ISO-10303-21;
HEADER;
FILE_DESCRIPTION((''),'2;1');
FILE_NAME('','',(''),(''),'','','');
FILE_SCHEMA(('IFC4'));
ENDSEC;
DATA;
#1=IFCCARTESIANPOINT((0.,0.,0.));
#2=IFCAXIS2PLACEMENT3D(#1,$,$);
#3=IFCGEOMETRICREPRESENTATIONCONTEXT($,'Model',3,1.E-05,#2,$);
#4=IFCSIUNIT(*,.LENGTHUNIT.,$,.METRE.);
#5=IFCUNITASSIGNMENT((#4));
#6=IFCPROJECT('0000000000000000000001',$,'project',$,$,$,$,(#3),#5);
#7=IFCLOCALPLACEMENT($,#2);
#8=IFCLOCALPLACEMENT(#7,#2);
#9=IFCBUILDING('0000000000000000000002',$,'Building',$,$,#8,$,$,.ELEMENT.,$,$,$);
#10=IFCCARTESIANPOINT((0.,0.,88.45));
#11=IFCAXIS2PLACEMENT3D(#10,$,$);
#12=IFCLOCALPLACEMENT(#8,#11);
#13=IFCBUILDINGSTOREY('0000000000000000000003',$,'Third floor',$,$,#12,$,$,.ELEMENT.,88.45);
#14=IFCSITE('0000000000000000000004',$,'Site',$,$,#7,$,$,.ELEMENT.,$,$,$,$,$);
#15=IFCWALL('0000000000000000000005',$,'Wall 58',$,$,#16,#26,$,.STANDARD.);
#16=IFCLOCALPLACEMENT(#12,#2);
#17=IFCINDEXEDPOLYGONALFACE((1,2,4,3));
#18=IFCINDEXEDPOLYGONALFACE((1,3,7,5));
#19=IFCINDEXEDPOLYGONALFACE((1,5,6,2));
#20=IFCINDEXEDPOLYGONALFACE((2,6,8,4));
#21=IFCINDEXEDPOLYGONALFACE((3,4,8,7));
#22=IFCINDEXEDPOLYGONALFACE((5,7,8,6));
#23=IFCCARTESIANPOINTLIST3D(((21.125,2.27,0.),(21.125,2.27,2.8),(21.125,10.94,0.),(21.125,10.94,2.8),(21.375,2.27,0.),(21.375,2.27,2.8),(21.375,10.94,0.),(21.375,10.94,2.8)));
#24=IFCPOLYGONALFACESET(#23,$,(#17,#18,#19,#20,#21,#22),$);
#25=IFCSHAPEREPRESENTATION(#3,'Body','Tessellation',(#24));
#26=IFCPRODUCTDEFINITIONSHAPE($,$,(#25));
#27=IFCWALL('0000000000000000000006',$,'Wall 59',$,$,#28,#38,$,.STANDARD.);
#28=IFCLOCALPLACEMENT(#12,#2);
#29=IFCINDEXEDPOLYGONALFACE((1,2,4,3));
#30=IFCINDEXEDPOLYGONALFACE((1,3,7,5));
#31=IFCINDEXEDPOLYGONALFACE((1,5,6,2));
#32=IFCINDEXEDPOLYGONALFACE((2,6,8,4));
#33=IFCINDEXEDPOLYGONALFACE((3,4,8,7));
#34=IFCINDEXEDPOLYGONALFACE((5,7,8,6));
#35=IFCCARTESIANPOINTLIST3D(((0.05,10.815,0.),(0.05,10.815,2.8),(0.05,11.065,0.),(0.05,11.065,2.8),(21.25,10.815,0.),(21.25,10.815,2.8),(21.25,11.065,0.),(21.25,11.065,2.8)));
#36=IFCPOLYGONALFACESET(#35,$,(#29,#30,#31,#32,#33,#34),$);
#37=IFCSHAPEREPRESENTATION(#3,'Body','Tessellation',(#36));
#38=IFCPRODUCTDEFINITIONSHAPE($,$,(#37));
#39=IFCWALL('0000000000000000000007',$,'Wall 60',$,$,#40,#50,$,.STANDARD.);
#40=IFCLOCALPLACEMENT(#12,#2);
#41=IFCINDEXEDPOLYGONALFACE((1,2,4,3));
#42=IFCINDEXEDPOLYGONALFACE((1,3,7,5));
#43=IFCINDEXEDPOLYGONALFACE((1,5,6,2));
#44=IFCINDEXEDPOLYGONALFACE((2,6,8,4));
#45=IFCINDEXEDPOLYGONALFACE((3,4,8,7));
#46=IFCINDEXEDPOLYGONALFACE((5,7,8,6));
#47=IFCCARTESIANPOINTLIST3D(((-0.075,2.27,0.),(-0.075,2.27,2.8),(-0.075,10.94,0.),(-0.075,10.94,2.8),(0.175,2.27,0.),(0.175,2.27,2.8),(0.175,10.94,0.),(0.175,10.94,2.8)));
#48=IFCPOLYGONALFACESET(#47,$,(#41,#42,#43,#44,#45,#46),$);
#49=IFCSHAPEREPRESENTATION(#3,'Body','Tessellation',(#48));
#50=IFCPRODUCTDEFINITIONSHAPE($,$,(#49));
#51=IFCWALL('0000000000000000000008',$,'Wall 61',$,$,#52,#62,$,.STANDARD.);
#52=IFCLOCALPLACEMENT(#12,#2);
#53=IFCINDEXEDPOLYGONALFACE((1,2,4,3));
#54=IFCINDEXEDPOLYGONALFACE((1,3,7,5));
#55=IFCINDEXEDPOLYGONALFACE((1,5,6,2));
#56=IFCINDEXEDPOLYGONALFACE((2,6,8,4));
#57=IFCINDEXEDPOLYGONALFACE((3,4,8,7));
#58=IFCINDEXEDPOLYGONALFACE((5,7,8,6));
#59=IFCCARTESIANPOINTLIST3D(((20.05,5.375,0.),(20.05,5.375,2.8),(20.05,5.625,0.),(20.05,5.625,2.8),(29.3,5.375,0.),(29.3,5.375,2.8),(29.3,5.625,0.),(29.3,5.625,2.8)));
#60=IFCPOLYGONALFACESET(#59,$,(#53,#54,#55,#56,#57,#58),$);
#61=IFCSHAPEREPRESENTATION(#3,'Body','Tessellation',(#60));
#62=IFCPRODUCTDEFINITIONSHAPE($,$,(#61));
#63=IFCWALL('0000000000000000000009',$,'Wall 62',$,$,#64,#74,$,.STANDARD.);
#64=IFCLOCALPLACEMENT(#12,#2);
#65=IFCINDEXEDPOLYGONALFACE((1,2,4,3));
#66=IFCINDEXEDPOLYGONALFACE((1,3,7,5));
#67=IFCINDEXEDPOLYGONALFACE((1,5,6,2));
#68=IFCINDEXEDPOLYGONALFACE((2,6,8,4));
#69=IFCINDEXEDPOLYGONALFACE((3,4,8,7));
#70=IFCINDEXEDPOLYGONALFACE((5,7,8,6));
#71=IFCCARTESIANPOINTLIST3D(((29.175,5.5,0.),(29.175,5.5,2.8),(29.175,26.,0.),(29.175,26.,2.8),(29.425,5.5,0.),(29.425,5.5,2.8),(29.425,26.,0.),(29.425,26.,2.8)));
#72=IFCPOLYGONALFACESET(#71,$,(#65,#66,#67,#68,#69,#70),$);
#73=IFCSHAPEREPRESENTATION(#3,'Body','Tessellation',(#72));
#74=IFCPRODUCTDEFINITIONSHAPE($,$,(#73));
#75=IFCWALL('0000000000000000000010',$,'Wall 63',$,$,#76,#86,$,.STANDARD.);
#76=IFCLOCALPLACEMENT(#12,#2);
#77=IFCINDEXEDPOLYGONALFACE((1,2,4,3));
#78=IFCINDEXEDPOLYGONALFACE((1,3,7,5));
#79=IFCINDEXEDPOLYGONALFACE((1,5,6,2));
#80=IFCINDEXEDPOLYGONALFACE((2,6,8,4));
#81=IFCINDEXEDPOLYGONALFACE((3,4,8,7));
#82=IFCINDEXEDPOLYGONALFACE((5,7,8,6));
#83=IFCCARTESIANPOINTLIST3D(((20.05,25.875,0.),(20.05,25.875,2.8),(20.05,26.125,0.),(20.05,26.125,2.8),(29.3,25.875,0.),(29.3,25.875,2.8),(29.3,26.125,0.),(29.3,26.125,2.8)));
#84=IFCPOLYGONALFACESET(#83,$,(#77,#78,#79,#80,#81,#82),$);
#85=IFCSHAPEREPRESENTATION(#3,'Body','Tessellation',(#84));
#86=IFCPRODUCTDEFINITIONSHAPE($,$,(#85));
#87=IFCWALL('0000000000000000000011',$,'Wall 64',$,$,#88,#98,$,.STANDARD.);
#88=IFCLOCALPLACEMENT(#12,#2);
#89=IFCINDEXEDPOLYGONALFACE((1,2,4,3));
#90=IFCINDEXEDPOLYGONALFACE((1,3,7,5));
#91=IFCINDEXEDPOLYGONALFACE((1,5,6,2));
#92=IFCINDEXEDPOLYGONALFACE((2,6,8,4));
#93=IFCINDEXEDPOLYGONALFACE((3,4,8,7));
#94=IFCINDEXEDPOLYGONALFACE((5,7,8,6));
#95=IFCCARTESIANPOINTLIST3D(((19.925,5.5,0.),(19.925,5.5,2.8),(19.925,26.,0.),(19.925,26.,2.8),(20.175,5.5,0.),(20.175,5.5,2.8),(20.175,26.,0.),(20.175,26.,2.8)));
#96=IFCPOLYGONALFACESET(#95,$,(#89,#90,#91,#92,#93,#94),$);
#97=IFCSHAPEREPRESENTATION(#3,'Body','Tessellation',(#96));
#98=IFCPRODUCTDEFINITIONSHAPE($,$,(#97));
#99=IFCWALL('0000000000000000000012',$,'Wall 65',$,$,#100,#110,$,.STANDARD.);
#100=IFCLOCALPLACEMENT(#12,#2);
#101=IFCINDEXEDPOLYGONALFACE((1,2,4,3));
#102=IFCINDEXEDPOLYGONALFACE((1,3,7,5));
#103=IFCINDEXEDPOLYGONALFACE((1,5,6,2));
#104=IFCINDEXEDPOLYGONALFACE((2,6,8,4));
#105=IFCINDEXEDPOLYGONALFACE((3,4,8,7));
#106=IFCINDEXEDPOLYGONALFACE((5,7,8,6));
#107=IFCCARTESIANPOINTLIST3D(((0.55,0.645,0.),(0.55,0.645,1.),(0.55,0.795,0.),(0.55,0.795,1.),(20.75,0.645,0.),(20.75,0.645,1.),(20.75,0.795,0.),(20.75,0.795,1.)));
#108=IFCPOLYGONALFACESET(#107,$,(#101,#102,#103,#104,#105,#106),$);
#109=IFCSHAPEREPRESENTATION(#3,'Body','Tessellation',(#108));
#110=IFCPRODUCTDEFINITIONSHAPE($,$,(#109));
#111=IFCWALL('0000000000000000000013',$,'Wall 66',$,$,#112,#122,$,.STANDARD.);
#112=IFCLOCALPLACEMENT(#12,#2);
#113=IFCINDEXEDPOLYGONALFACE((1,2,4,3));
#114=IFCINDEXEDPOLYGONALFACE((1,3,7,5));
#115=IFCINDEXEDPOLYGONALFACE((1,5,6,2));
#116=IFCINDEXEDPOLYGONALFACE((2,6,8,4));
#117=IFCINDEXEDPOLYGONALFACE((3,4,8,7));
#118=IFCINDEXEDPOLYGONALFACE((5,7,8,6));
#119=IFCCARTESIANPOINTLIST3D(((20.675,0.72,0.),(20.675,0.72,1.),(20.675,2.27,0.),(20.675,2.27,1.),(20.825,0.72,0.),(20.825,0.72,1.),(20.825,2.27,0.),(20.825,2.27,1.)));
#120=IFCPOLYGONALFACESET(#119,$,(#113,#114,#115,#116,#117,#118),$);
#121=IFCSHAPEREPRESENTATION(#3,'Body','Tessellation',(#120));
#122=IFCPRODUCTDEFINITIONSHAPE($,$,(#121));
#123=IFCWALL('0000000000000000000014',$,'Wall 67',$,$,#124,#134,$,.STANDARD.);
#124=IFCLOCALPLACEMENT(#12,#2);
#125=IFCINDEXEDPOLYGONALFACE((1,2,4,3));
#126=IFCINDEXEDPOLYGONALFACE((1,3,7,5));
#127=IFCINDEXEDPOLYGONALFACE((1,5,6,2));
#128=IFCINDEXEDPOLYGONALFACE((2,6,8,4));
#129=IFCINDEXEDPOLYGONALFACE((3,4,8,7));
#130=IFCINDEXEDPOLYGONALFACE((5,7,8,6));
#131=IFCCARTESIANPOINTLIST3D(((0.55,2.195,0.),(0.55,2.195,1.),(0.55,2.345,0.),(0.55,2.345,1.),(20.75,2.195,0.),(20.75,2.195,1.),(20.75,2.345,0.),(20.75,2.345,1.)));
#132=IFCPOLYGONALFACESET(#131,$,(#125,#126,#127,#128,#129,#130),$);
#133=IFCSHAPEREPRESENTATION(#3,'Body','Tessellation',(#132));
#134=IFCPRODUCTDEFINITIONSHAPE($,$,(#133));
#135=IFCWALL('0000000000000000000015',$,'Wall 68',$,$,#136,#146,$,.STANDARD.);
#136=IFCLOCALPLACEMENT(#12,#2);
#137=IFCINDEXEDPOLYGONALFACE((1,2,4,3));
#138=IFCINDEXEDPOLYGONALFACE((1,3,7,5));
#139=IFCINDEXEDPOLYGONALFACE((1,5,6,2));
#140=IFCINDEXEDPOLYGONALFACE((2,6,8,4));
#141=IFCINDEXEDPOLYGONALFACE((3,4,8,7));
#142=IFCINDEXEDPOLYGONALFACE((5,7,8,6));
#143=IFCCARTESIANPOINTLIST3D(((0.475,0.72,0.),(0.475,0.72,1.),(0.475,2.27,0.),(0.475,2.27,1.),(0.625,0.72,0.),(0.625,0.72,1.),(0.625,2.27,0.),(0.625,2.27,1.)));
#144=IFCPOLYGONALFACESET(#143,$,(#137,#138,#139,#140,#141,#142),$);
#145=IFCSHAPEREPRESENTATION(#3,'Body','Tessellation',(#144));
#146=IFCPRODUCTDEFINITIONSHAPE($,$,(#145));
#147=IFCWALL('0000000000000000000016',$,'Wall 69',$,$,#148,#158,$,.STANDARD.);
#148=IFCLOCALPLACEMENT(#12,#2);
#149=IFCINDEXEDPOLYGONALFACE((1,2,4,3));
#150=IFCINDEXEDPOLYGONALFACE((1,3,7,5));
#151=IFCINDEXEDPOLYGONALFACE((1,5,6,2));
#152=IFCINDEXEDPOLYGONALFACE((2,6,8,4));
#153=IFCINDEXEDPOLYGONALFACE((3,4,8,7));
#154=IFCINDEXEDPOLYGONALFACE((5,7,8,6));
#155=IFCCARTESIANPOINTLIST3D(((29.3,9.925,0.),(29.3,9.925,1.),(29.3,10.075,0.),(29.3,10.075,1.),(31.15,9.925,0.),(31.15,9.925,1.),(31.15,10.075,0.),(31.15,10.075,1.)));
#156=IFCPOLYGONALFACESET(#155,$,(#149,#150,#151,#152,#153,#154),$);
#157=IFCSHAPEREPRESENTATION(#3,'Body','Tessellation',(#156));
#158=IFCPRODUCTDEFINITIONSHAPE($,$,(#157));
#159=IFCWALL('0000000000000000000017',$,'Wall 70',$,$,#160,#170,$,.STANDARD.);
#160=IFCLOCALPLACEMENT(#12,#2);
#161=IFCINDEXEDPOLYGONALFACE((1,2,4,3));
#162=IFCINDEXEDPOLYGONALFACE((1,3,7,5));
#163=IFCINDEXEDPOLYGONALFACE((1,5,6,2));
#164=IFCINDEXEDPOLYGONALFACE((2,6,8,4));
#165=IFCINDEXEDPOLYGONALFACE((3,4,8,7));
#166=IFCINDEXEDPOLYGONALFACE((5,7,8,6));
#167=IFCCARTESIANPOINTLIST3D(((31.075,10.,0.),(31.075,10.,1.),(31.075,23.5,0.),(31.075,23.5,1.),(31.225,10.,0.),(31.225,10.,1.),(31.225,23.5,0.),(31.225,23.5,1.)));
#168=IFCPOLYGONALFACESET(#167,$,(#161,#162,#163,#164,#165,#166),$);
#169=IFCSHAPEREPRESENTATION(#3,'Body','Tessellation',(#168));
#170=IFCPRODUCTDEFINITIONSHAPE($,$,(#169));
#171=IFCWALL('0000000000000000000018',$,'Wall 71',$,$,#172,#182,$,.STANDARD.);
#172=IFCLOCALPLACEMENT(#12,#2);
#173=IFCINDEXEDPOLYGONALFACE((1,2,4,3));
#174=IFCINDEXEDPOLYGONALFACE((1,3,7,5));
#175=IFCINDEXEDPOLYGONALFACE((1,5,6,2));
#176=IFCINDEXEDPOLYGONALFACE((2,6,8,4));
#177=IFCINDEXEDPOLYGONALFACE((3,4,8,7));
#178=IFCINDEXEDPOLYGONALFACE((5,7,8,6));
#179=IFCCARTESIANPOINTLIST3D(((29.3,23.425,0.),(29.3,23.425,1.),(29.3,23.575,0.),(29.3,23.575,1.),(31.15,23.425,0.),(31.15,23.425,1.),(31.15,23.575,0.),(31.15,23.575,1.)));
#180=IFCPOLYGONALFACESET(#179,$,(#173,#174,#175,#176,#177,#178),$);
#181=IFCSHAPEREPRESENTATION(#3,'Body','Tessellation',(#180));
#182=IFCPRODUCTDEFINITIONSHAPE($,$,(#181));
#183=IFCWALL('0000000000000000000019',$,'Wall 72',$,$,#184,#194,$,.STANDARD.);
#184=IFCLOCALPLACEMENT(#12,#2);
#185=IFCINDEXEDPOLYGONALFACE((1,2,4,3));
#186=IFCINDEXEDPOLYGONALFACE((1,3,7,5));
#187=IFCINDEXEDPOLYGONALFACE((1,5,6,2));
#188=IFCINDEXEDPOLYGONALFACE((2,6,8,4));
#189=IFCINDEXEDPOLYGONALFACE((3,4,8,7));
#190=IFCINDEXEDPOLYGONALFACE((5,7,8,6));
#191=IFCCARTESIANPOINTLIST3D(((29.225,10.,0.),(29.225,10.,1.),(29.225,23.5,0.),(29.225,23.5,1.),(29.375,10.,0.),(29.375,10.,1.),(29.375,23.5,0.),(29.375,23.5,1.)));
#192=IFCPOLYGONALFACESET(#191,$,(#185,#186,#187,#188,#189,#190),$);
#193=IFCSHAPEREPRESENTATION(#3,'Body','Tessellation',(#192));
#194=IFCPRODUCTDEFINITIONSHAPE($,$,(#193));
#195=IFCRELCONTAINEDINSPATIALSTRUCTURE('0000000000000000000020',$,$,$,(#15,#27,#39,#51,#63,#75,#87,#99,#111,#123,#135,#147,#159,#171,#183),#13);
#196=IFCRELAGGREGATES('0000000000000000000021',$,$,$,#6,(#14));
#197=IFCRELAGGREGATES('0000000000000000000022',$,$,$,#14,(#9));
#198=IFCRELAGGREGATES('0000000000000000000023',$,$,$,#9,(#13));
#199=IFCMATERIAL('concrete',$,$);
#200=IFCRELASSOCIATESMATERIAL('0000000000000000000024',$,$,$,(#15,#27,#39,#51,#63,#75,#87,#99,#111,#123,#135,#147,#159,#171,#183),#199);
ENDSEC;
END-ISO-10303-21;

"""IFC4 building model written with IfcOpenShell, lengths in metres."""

from ifc_helpers import new_model, si_unit, frame, frame_2d, origin, place, context, project, spatial, rectangle, extrude, material, element, save


model = new_model("IFC4")

# Units and contexts
model_context = context("Model", 3, precision=1e-05, world=origin())
ifc_project = project(units=[si_unit("LENGTHUNIT", "METRE")], contexts=[model_context])

# Site, building, storey
site_placement = place(None, origin())
site = spatial("IfcSite", under=ifc_project, at=site_placement, Name="Site", CompositionType="ELEMENT")
building_placement = place(site_placement, origin())
building = spatial("IfcBuilding", under=site, at=building_placement, Name="Building", CompositionType="ELEMENT")
storey_placement = place(building_placement, frame((0.0, 0.0, 88.45)))
storey = spatial("IfcBuildingStorey", under=building, at=storey_placement, Name="Third floor", CompositionType="ELEMENT", Elevation=88.45)

# Shared definitions
ifc_material = material(Name="concrete")

# Walls
wall_1_placement = place(storey_placement, frame((21.25, 2.27, 0.0), z_axis=(0.0, 0.0, 1.0), x_axis=(0.0, 1.0, 0.0)))
element("IfcWall", 1, at=wall_1_placement, inside=storey, material=ifc_material, Name="Wall 58", PredefinedType="STANDARD", context=model_context, shape_type="SweptSolid", body=[
    extrude(rectangle(XDim=8.67, YDim=0.25, at=frame_2d((4.335, 0.0))), origin(), (0.0, 0.0, 1.0), 2.8),
])
wall_2_placement = place(storey_placement, frame((21.25, 10.94, 0.0), z_axis=(0.0, 0.0, 1.0), x_axis=(-1.0, 0.0, 0.0)))
element("IfcWall", 2, at=wall_2_placement, inside=storey, material=ifc_material, Name="Wall 59", PredefinedType="STANDARD", context=model_context, shape_type="SweptSolid", body=[
    extrude(rectangle(XDim=21.2, YDim=0.25, at=frame_2d((10.6, 0.0))), origin(), (0.0, 0.0, 1.0), 2.8),
])
wall_3_placement = place(storey_placement, frame((0.05, 10.94, 0.0), z_axis=(0.0, 0.0, 1.0), x_axis=(0.0, -1.0, 0.0)))
element("IfcWall", 3, at=wall_3_placement, inside=storey, material=ifc_material, Name="Wall 60", PredefinedType="STANDARD", context=model_context, shape_type="SweptSolid", body=[
    extrude(rectangle(XDim=8.67, YDim=0.25, at=frame_2d((4.335, 0.0))), origin(), (0.0, 0.0, 1.0), 2.8),
])
wall_4_placement = place(storey_placement, frame((20.05, 5.5, 0.0), z_axis=(0.0, 0.0, 1.0), x_axis=(1.0, 0.0, 0.0)))
element("IfcWall", 4, at=wall_4_placement, inside=storey, material=ifc_material, Name="Wall 61", PredefinedType="STANDARD", context=model_context, shape_type="SweptSolid", body=[
    extrude(rectangle(XDim=9.25, YDim=0.25, at=frame_2d((4.625, 0.0))), origin(), (0.0, 0.0, 1.0), 2.8),
])
wall_5_placement = place(storey_placement, frame((29.3, 5.5, 0.0), z_axis=(0.0, 0.0, 1.0), x_axis=(0.0, 1.0, 0.0)))
element("IfcWall", 5, at=wall_5_placement, inside=storey, material=ifc_material, Name="Wall 62", PredefinedType="STANDARD", context=model_context, shape_type="SweptSolid", body=[
    extrude(rectangle(XDim=20.5, YDim=0.25, at=frame_2d((10.25, 0.0))), origin(), (0.0, 0.0, 1.0), 2.8),
])
wall_6_placement = place(storey_placement, frame((29.3, 26.0, 0.0), z_axis=(0.0, 0.0, 1.0), x_axis=(-1.0, 0.0, 0.0)))
element("IfcWall", 6, at=wall_6_placement, inside=storey, material=ifc_material, Name="Wall 63", PredefinedType="STANDARD", context=model_context, shape_type="SweptSolid", body=[
    extrude(rectangle(XDim=9.25, YDim=0.25, at=frame_2d((4.625, 0.0))), origin(), (0.0, 0.0, 1.0), 2.8),
])
wall_7_placement = place(storey_placement, frame((20.05, 26.0, 0.0), z_axis=(0.0, 0.0, 1.0), x_axis=(0.0, -1.0, 0.0)))
element("IfcWall", 7, at=wall_7_placement, inside=storey, material=ifc_material, Name="Wall 64", PredefinedType="STANDARD", context=model_context, shape_type="SweptSolid", body=[
    extrude(rectangle(XDim=20.5, YDim=0.25, at=frame_2d((10.25, 0.0))), origin(), (0.0, 0.0, 1.0), 2.8),
])
wall_8_placement = place(storey_placement, frame((0.55, 0.72, 0.0), z_axis=(0.0, 0.0, 1.0), x_axis=(1.0, 0.0, 0.0)))
element("IfcWall", 8, at=wall_8_placement, inside=storey, material=ifc_material, Name="Wall 65", PredefinedType="STANDARD", context=model_context, shape_type="SweptSolid", body=[
    extrude(rectangle(XDim=20.2, YDim=0.15, at=frame_2d((10.1, 0.0))), origin(), (0.0, 0.0, 1.0), 1.0),
])
wall_9_placement = place(storey_placement, frame((20.75, 0.72, 0.0), z_axis=(0.0, 0.0, 1.0), x_axis=(0.0, 1.0, 0.0)))
element("IfcWall", 9, at=wall_9_placement, inside=storey, material=ifc_material, Name="Wall 66", PredefinedType="STANDARD", context=model_context, shape_type="SweptSolid", body=[
    extrude(rectangle(XDim=1.55, YDim=0.15, at=frame_2d((0.775, 0.0))), origin(), (0.0, 0.0, 1.0), 1.0),
])
wall_10_placement = place(storey_placement, frame((20.75, 2.27, 0.0), z_axis=(0.0, 0.0, 1.0), x_axis=(-1.0, 0.0, 0.0)))
element("IfcWall", 10, at=wall_10_placement, inside=storey, material=ifc_material, Name="Wall 67", PredefinedType="STANDARD", context=model_context, shape_type="SweptSolid", body=[
    extrude(rectangle(XDim=20.2, YDim=0.15, at=frame_2d((10.1, 0.0))), origin(), (0.0, 0.0, 1.0), 1.0),
])
wall_11_placement = place(storey_placement, frame((0.55, 2.27, 0.0), z_axis=(0.0, 0.0, 1.0), x_axis=(0.0, -1.0, 0.0)))
element("IfcWall", 11, at=wall_11_placement, inside=storey, material=ifc_material, Name="Wall 68", PredefinedType="STANDARD", context=model_context, shape_type="SweptSolid", body=[
    extrude(rectangle(XDim=1.55, YDim=0.15, at=frame_2d((0.775, 0.0))), origin(), (0.0, 0.0, 1.0), 1.0),
])
wall_12_placement = place(storey_placement, frame((29.3, 10.0, 0.0), z_axis=(0.0, 0.0, 1.0), x_axis=(1.0, 0.0, 0.0)))
element("IfcWall", 12, at=wall_12_placement, inside=storey, material=ifc_material, Name="Wall 69", PredefinedType="STANDARD", context=model_context, shape_type="SweptSolid", body=[
    extrude(rectangle(XDim=1.85, YDim=0.15, at=frame_2d((0.925, 0.0))), origin(), (0.0, 0.0, 1.0), 1.0),
])
wall_13_placement = place(storey_placement, frame((31.15, 10.0, 0.0), z_axis=(0.0, 0.0, 1.0), x_axis=(0.0, 1.0, 0.0)))
element("IfcWall", 13, at=wall_13_placement, inside=storey, material=ifc_material, Name="Wall 70", PredefinedType="STANDARD", context=model_context, shape_type="SweptSolid", body=[
    extrude(rectangle(XDim=13.5, YDim=0.15, at=frame_2d((6.75, 0.0))), origin(), (0.0, 0.0, 1.0), 1.0),
])
wall_14_placement = place(storey_placement, frame((31.15, 23.5, 0.0), z_axis=(0.0, 0.0, 1.0), x_axis=(-1.0, 0.0, 0.0)))
element("IfcWall", 14, at=wall_14_placement, inside=storey, material=ifc_material, Name="Wall 71", PredefinedType="STANDARD", context=model_context, shape_type="SweptSolid", body=[
    extrude(rectangle(XDim=1.85, YDim=0.15, at=frame_2d((0.925, 0.0))), origin(), (0.0, 0.0, 1.0), 1.0),
])
wall_15_placement = place(storey_placement, frame((29.3, 23.5, 0.0), z_axis=(0.0, 0.0, 1.0), x_axis=(0.0, -1.0, 0.0)))
element("IfcWall", 15, at=wall_15_placement, inside=storey, material=ifc_material, Name="Wall 72", PredefinedType="STANDARD", context=model_context, shape_type="SweptSolid", body=[
    extrude(rectangle(XDim=13.5, YDim=0.15, at=frame_2d((6.75, 0.0))), origin(), (0.0, 0.0, 1.0), 1.0),
])

save(model, "model.ifc")
